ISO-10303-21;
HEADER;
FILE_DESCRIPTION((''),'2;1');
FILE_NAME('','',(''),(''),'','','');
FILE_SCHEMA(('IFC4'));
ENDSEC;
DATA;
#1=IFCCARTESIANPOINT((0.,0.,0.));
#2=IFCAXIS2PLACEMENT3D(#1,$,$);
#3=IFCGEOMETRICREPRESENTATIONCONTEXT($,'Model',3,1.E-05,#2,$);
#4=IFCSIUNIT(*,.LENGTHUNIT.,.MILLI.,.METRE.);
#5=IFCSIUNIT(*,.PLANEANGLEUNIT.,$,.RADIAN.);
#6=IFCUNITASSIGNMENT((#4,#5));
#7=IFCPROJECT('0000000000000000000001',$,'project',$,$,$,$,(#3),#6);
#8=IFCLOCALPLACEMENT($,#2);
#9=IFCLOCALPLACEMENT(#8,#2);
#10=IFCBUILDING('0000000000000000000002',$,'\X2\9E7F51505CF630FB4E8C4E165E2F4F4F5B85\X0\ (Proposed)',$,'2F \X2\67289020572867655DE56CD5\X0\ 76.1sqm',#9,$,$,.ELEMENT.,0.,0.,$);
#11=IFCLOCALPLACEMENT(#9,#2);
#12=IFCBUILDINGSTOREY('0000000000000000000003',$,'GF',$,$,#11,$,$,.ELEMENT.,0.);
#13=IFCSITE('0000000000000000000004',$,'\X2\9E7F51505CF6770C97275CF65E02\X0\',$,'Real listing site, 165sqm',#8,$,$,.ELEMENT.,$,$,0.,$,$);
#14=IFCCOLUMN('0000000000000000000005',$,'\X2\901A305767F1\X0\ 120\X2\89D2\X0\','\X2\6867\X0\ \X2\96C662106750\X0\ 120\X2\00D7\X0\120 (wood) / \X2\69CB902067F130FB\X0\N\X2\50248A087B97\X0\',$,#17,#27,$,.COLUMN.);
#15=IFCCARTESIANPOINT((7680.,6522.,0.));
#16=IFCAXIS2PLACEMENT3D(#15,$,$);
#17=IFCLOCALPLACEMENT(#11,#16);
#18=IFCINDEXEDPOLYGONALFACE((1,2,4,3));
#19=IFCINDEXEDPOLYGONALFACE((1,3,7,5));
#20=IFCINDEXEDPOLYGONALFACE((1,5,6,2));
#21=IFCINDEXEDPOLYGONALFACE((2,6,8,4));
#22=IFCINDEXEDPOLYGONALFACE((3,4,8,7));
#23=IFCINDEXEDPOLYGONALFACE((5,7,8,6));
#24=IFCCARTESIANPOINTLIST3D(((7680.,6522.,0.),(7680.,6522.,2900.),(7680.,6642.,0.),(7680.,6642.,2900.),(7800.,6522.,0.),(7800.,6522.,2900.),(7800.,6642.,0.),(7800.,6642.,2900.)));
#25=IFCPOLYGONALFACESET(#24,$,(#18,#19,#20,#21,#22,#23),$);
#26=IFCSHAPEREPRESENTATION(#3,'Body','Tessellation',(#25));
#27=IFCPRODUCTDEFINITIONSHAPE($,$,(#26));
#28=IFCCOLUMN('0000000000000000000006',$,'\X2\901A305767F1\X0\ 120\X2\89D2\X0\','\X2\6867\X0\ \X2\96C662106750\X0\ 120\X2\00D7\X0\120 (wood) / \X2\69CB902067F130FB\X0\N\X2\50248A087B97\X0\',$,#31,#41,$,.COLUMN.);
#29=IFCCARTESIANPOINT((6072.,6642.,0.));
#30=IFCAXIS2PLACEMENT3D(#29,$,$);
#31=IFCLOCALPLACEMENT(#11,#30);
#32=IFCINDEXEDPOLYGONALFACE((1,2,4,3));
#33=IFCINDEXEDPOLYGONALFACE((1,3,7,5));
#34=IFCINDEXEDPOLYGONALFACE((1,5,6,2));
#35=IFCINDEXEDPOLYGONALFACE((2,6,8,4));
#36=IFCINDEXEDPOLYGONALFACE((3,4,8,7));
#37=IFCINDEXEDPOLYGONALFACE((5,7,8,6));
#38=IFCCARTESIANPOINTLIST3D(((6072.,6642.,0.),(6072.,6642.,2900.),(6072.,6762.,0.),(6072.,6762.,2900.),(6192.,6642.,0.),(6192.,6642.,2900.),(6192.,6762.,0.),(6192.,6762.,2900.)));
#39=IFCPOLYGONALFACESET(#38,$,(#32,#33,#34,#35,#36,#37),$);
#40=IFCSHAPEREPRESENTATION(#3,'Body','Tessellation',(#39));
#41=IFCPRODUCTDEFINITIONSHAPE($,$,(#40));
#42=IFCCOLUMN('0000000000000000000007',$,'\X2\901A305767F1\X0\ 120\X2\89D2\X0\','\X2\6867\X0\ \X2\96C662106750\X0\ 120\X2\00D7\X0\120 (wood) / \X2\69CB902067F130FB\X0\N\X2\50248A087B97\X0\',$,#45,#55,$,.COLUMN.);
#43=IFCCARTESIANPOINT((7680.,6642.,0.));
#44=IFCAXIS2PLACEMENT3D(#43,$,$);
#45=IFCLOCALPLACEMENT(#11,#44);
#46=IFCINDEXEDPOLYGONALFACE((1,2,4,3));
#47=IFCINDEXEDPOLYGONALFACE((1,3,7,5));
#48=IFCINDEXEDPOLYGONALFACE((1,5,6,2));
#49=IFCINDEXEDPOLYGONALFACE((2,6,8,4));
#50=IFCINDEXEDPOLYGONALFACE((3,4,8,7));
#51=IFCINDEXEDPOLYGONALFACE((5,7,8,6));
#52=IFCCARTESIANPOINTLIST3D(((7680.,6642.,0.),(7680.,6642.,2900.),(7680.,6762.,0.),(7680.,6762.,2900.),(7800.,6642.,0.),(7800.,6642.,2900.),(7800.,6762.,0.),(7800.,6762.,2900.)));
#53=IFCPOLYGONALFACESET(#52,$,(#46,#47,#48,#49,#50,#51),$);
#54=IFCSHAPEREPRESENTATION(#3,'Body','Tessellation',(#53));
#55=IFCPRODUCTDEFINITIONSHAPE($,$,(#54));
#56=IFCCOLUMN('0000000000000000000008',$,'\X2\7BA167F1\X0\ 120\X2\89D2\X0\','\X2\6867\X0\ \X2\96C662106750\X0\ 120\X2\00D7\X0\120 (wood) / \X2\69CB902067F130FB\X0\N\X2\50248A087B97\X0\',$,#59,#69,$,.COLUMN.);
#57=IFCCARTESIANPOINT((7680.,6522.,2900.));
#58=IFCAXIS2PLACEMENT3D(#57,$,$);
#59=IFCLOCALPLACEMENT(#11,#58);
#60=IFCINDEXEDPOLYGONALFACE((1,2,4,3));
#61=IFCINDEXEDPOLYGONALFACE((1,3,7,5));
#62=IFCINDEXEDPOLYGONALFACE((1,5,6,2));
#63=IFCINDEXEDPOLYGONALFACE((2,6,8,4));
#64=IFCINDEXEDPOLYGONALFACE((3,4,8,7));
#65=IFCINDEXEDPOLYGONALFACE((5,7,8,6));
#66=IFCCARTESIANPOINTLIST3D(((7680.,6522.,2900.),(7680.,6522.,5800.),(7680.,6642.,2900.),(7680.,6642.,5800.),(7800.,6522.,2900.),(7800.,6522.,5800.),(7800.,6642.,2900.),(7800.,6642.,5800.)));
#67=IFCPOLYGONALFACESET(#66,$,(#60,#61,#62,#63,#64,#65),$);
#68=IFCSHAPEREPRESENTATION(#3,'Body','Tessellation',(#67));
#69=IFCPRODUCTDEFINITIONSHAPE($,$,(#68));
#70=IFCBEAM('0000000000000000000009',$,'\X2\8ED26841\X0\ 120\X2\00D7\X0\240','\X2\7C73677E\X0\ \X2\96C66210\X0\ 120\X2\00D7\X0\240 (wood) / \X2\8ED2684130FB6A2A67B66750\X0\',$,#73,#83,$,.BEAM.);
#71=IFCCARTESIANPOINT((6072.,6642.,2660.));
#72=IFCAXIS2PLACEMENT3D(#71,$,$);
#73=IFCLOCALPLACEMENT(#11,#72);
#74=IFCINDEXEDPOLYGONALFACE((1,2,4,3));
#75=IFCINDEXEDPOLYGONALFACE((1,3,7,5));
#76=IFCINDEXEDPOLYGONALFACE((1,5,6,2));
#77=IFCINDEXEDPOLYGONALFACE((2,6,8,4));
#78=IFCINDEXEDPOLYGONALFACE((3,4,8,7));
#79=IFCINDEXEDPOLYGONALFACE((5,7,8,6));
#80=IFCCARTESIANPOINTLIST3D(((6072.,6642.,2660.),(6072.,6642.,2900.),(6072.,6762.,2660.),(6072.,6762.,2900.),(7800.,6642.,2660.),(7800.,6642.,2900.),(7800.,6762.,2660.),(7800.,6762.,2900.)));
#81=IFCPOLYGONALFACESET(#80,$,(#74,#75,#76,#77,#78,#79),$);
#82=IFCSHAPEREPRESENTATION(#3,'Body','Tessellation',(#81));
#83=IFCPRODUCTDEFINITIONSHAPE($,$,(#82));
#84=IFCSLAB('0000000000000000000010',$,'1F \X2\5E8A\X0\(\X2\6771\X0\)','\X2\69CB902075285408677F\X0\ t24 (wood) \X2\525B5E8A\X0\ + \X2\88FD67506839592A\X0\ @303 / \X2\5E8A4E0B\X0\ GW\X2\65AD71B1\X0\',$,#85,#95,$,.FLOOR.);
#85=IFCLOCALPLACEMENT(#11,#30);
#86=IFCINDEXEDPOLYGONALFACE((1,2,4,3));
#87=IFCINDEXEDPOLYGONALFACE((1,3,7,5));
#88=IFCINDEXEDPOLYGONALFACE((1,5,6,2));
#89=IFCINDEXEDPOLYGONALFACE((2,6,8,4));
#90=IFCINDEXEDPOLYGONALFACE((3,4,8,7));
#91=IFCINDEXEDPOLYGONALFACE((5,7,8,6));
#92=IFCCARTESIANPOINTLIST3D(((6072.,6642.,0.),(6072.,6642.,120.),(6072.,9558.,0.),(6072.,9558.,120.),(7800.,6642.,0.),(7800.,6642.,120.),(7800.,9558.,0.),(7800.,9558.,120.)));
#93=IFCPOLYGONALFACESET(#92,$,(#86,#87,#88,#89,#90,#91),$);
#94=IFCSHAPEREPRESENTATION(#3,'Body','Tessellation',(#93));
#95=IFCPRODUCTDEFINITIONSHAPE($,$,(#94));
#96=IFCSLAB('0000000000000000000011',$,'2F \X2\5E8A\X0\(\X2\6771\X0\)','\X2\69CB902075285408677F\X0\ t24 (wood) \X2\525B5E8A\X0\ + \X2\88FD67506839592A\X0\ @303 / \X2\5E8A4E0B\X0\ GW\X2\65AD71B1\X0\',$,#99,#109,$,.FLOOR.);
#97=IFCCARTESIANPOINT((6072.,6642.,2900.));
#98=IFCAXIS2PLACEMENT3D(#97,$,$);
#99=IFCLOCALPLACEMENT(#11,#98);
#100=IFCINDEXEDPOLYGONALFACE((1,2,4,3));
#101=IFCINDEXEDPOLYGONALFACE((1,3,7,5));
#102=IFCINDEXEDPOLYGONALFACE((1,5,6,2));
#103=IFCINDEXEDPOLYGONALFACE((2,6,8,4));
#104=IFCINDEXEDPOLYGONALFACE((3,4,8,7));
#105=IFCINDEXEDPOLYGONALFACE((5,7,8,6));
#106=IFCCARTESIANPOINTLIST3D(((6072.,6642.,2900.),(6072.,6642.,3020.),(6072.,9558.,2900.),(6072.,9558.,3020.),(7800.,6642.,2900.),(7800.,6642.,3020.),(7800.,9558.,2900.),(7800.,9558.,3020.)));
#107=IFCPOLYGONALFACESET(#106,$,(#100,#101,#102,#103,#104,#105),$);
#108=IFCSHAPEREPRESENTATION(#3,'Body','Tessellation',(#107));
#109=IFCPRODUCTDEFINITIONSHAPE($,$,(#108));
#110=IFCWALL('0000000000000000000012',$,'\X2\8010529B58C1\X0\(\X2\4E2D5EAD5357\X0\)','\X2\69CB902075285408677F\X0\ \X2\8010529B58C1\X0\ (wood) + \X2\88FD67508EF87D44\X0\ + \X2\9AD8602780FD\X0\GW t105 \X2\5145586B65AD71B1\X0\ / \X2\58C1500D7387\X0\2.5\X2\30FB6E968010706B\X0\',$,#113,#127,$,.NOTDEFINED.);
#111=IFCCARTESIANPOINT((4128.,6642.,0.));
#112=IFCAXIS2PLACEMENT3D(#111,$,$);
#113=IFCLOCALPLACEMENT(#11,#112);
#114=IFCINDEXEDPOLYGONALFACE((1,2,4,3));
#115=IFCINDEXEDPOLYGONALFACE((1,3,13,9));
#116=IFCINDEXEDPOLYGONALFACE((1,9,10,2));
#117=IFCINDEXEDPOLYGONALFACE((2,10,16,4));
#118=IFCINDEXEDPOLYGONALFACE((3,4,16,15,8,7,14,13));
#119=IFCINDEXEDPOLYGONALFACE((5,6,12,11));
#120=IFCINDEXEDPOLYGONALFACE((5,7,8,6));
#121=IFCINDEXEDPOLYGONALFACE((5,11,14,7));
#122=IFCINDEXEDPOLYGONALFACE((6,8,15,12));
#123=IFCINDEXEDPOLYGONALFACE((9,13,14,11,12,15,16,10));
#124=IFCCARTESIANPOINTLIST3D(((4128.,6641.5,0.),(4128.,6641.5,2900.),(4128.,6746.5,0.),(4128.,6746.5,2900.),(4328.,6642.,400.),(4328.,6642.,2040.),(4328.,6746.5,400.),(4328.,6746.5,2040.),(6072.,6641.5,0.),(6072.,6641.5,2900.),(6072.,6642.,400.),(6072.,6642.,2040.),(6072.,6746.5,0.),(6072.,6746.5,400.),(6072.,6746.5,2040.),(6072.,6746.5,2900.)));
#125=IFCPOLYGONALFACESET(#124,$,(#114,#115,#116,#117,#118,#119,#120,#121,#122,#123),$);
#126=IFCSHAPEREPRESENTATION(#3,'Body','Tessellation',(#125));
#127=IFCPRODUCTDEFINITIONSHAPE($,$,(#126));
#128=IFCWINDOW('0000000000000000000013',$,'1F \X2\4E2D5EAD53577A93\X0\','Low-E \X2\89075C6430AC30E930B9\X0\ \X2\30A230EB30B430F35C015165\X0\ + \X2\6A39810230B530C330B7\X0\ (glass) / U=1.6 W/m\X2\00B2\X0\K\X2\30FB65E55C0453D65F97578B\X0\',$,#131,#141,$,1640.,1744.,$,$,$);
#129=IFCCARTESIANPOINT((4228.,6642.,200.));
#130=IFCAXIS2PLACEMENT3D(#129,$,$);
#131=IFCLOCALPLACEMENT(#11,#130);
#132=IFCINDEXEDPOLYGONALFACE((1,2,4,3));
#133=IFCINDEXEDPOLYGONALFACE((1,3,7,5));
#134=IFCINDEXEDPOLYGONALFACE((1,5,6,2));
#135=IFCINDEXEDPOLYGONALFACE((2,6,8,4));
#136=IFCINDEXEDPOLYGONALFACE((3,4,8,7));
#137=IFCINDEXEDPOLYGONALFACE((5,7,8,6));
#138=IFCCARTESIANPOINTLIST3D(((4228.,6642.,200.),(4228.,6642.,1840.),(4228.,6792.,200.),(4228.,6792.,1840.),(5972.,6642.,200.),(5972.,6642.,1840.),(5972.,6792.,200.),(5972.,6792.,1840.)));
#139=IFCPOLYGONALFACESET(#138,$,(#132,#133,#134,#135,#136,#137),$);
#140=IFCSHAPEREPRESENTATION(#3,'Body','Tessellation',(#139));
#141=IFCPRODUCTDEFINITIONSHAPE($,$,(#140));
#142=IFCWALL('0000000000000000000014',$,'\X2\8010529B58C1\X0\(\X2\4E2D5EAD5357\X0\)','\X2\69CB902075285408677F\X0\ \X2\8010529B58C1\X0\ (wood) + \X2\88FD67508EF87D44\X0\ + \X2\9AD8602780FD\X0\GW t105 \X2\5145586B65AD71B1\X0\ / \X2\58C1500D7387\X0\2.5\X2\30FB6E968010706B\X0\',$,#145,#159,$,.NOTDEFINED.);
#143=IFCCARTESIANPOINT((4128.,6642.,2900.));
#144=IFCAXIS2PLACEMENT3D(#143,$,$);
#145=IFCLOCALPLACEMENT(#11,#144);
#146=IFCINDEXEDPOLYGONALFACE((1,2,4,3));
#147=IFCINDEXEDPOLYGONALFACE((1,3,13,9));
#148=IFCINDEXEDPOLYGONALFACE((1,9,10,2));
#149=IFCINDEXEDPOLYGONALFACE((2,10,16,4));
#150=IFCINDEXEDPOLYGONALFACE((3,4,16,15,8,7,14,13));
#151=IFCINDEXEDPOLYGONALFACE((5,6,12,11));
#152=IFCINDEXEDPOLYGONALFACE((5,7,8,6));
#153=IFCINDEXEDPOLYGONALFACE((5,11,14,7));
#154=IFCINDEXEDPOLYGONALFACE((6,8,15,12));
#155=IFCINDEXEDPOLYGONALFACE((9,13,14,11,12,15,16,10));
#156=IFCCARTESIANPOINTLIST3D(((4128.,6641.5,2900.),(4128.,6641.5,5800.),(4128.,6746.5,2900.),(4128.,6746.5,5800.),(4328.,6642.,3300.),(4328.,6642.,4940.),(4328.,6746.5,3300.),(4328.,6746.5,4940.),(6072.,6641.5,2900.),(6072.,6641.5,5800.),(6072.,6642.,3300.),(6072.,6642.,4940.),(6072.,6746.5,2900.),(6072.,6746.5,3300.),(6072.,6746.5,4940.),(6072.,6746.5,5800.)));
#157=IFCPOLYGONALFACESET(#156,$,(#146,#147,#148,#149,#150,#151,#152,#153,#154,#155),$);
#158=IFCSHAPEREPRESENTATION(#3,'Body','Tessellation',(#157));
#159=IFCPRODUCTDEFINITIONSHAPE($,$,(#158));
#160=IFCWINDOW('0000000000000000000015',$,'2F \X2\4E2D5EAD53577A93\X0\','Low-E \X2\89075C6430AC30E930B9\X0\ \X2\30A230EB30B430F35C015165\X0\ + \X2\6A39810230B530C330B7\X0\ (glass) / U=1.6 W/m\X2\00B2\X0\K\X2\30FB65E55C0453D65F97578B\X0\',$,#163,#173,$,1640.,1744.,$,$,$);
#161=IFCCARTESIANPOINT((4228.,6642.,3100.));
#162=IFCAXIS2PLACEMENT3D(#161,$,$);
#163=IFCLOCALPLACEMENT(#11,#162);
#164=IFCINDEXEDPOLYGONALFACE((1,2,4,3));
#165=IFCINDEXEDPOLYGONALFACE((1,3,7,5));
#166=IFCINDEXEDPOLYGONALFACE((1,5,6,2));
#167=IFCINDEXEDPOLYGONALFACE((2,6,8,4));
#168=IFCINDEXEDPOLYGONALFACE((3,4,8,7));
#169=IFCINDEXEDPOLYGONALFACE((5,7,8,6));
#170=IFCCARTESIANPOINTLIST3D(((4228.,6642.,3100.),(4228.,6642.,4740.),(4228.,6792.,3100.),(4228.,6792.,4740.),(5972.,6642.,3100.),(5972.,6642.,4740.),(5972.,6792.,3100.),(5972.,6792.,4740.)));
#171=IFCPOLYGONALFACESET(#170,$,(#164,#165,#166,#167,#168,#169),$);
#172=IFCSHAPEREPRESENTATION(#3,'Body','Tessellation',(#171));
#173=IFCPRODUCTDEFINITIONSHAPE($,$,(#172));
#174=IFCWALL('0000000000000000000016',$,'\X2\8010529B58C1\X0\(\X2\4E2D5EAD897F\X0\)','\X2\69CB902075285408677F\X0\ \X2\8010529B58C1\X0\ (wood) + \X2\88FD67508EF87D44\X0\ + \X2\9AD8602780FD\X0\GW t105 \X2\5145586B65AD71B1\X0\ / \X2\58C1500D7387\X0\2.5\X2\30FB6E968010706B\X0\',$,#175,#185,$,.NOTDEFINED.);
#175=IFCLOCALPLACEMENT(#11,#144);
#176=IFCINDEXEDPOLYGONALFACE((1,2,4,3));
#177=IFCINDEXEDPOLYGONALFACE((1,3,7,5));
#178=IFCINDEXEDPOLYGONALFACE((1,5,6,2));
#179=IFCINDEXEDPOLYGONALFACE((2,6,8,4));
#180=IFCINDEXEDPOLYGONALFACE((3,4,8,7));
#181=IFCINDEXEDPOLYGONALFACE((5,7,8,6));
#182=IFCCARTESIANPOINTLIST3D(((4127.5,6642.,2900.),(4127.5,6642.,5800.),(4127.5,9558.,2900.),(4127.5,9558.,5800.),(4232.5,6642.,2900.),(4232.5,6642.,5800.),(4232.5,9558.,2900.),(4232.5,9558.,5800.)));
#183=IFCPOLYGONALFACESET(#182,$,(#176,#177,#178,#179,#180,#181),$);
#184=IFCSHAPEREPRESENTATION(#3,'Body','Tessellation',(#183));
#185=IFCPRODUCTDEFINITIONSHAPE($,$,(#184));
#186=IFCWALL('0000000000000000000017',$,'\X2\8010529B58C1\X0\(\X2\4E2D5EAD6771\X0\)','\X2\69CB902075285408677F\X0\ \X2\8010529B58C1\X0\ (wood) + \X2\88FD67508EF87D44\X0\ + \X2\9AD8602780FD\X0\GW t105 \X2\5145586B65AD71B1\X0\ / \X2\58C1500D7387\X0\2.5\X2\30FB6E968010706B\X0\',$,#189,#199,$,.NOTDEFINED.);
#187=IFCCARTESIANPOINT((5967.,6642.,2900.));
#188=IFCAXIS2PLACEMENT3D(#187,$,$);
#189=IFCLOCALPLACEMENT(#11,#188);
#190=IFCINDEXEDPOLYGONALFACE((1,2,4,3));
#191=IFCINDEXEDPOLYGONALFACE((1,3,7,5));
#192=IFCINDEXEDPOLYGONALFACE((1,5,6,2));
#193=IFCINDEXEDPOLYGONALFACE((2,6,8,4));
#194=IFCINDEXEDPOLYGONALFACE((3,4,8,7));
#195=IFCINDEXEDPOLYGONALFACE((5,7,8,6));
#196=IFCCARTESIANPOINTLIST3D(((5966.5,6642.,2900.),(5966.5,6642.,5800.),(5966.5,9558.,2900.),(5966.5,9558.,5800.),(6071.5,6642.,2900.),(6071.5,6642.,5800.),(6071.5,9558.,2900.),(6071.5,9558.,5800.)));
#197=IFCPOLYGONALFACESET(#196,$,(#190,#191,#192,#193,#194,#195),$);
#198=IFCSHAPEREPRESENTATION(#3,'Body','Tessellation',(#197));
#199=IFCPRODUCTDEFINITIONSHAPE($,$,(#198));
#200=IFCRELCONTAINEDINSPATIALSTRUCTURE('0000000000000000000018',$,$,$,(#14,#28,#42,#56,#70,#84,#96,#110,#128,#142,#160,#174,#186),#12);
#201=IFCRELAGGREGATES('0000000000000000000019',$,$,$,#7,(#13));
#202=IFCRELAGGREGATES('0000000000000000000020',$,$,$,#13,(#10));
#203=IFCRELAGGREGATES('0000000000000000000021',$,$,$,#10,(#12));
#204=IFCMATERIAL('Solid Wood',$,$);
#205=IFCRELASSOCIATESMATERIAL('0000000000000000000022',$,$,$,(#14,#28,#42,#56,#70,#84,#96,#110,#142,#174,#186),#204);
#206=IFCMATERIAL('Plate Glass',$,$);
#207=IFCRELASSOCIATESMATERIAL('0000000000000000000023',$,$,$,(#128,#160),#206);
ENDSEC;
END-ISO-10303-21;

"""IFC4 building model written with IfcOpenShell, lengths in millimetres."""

from ifc_helpers import new_model, si_unit, frame, frame_2d, origin, place, context, project, spatial, rectangle, extrude, material, element, fill, save


model = new_model("IFC4")

# Units and contexts
model_context = context("Model", 3, precision=1e-05, world=origin())
ifc_project = project(units=[si_unit("LENGTHUNIT", "METRE", prefix="MILLI"), si_unit("PLANEANGLEUNIT", "RADIAN")], contexts=[model_context])

# Site, building, storey
site_placement = place(None, origin())
site = spatial("IfcSite", under=ifc_project, at=site_placement, Name="鹿児島県霧島市", ObjectType="Real listing site, 165sqm", CompositionType="ELEMENT", RefElevation=0.0)
building_placement = place(site_placement, origin())
building = spatial("IfcBuilding", under=site, at=building_placement, Name="鹿児島・二世帯住宅 (Proposed)", ObjectType="2F 木造在来工法 76.1sqm", CompositionType="ELEMENT", ElevationOfRefHeight=0.0, ElevationOfTerrain=0.0)
storey_placement = place(building_placement, origin())
storey = spatial("IfcBuildingStorey", under=building, at=storey_placement, Name="GF", CompositionType="ELEMENT", Elevation=0.0)

# Columns
ifc_material_1 = material(Name="Solid Wood")
column_1_placement = place(storey_placement, frame((7680.0, 6522.0, 0.0)))
element("IfcColumn", 1, at=column_1_placement, inside=storey, material=ifc_material_1, Name="通し柱 120角", Description="桧 集成材 120×120 (wood) / 構造柱・N値計算", PredefinedType="COLUMN", context=model_context, shape_type="SweptSolid", body=[
    extrude(rectangle(XDim=120.0, YDim=120.0, at=frame_2d((60.0, 60.0))), frame((7680.0, 6522.0, 0.0)), (0.0, 0.0, 1.0), 2900.0),
])
column_2_placement = place(storey_placement, frame((6072.0, 6642.0, 0.0)))
element("IfcColumn", 2, at=column_2_placement, inside=storey, material=ifc_material_1, Name="通し柱 120角", Description="桧 集成材 120×120 (wood) / 構造柱・N値計算", PredefinedType="COLUMN", context=model_context, shape_type="SweptSolid", body=[
    extrude(rectangle(XDim=120.0, YDim=120.0, at=frame_2d((60.0, 60.0))), frame((6072.0, 6642.0, 0.0)), (0.0, 0.0, 1.0), 2900.0),
])
column_3_placement = place(storey_placement, frame((7680.0, 6642.0, 0.0)))
element("IfcColumn", 3, at=column_3_placement, inside=storey, material=ifc_material_1, Name="通し柱 120角", Description="桧 集成材 120×120 (wood) / 構造柱・N値計算", PredefinedType="COLUMN", context=model_context, shape_type="SweptSolid", body=[
    extrude(rectangle(XDim=120.0, YDim=120.0, at=frame_2d((60.0, 60.0))), frame((7680.0, 6642.0, 0.0)), (0.0, 0.0, 1.0), 2900.0),
])
column_4_placement = place(storey_placement, frame((7680.0, 6522.0, 2900.0)))
element("IfcColumn", 4, at=column_4_placement, inside=storey, material=ifc_material_1, Name="管柱 120角", Description="桧 集成材 120×120 (wood) / 構造柱・N値計算", PredefinedType="COLUMN", context=model_context, shape_type="SweptSolid", body=[
    extrude(rectangle(XDim=120.0, YDim=120.0, at=frame_2d((60.0, 60.0))), frame((7680.0, 6522.0, 2900.0)), (0.0, 0.0, 1.0), 2900.0),
])

# Beam
beam_1_placement = place(storey_placement, frame((6072.0, 6642.0, 2660.0)))
element("IfcBeam", 5, at=beam_1_placement, inside=storey, material=ifc_material_1, Name="軒桁 120×240", Description="米松 集成 120×240 (wood) / 軒桁・横架材", PredefinedType="BEAM", context=model_context, shape_type="SweptSolid", body=[
    extrude(rectangle(XDim=1728.0, YDim=120.0, at=frame_2d((864.0, 60.0))), frame((6072.0, 6642.0, 2660.0)), (0.0, 0.0, 1.0), 240.0),
])

# Slabs
slab_1_placement = place(storey_placement, frame((6072.0, 6642.0, 0.0)))
element("IfcSlab", 6, at=slab_1_placement, inside=storey, material=ifc_material_1, Name="1F 床(東)", Description="構造用合板 t24 (wood) 剛床 + 製材根太 @303 / 床下 GW断熱", PredefinedType="FLOOR", context=model_context, shape_type="SweptSolid", body=[
    extrude(rectangle(XDim=1728.0, YDim=2916.0, at=frame_2d((864.0, 1458.0))), frame((6072.0, 6642.0, 0.0)), (0.0, 0.0, 1.0), 120.0),
])
slab_2_placement = place(storey_placement, frame((6072.0, 6642.0, 2900.0)))
element("IfcSlab", 7, at=slab_2_placement, inside=storey, material=ifc_material_1, Name="2F 床(東)", Description="構造用合板 t24 (wood) 剛床 + 製材根太 @303 / 床下 GW断熱", PredefinedType="FLOOR", context=model_context, shape_type="SweptSolid", body=[
    extrude(rectangle(XDim=1728.0, YDim=2916.0, at=frame_2d((864.0, 1458.0))), frame((6072.0, 6642.0, 2900.0)), (0.0, 0.0, 1.0), 120.0),
])

# Wall, opening, window
wall_1_placement = place(storey_placement, frame((4128.0, 6642.0, 0.0)))
wall_1 = element("IfcWall", 8, at=wall_1_placement, inside=storey, material=ifc_material_1, Name="耐力壁(中庭南)", Description="構造用合板 耐力壁 (wood) + 製材軸組 + 高性能GW t105 充填断熱 / 壁倍率2.5・準耐火", PredefinedType="NOTDEFINED", context=model_context, shape_type="SweptSolid", body=[
    extrude(rectangle(XDim=1944.0, YDim=105.0, at=frame_2d((972.0, 52.0))), frame((4128.0, 6642.0, 0.0)), (0.0, 0.0, 1.0), 2900.0),
])
opening_1_placement = place(storey_placement, frame((4228.0, 6642.0, 200.0)))
opening_1 = element("IfcOpeningElement", 9, at=opening_1_placement, cuts=wall_1, PredefinedType="NOTDEFINED", context=model_context, shape_type="SweptSolid", body=[
    extrude(rectangle(XDim=1744.0, YDim=150.0, at=frame_2d((872.0, 75.0))), frame((4228.0, 6642.0, 200.0)), (0.0, 0.0, 1.0), 1640.0),
])
ifc_material_2 = material(Name="Plate Glass")
window_1_placement = place(storey_placement, frame((4228.0, 6642.0, 200.0)))
window_1 = element("IfcWindow", 10, at=window_1_placement, inside=storey, material=ifc_material_2, Name="1F 中庭南窓", Description="Low-E 複層ガラス アルゴン封入 + 樹脂サッシ (glass) / U=1.6 W/m²K・日射取得型", OverallHeight=1640.0, OverallWidth=1744.0, context=model_context, shape_type="SweptSolid", body=[
    extrude(rectangle(XDim=1744.0, YDim=150.0, at=frame_2d((872.0, 75.0))), frame((4228.0, 6642.0, 200.0)), (0.0, 0.0, 1.0), 1640.0),
])
fill(opening_1, window_1)

# Wall, opening, window
wall_2_placement = place(storey_placement, frame((4128.0, 6642.0, 2900.0)))
wall_2 = element("IfcWall", 11, at=wall_2_placement, inside=storey, material=ifc_material_1, Name="耐力壁(中庭南)", Description="構造用合板 耐力壁 (wood) + 製材軸組 + 高性能GW t105 充填断熱 / 壁倍率2.5・準耐火", PredefinedType="NOTDEFINED", context=model_context, shape_type="SweptSolid", body=[
    extrude(rectangle(XDim=1944.0, YDim=105.0, at=frame_2d((972.0, 52.0))), frame((4128.0, 6642.0, 2900.0)), (0.0, 0.0, 1.0), 2900.0),
])
opening_2_placement = place(storey_placement, frame((4228.0, 6642.0, 3100.0)))
opening_2 = element("IfcOpeningElement", 12, at=opening_2_placement, cuts=wall_2, PredefinedType="NOTDEFINED", context=model_context, shape_type="SweptSolid", body=[
    extrude(rectangle(XDim=1744.0, YDim=150.0, at=frame_2d((872.0, 75.0))), frame((4228.0, 6642.0, 3100.0)), (0.0, 0.0, 1.0), 1640.0),
])
window_2_placement = place(storey_placement, frame((4228.0, 6642.0, 3100.0)))
window_2 = element("IfcWindow", 13, at=window_2_placement, inside=storey, material=ifc_material_2, Name="2F 中庭南窓", Description="Low-E 複層ガラス アルゴン封入 + 樹脂サッシ (glass) / U=1.6 W/m²K・日射取得型", OverallHeight=1640.0, OverallWidth=1744.0, context=model_context, shape_type="SweptSolid", body=[
    extrude(rectangle(XDim=1744.0, YDim=150.0, at=frame_2d((872.0, 75.0))), frame((4228.0, 6642.0, 3100.0)), (0.0, 0.0, 1.0), 1640.0),
])
fill(opening_2, window_2)

# Walls
wall_3_placement = place(storey_placement, frame((4128.0, 6642.0, 2900.0)))
element("IfcWall", 14, at=wall_3_placement, inside=storey, material=ifc_material_1, Name="耐力壁(中庭西)", Description="構造用合板 耐力壁 (wood) + 製材軸組 + 高性能GW t105 充填断熱 / 壁倍率2.5・準耐火", PredefinedType="NOTDEFINED", context=model_context, shape_type="SweptSolid", body=[
    extrude(rectangle(XDim=105.0, YDim=2916.0, at=frame_2d((52.0, 1458.0))), frame((4128.0, 6642.0, 2900.0)), (0.0, 0.0, 1.0), 2900.0),
])
wall_4_placement = place(storey_placement, frame((5967.0, 6642.0, 2900.0)))
element("IfcWall", 15, at=wall_4_placement, inside=storey, material=ifc_material_1, Name="耐力壁(中庭東)", Description="構造用合板 耐力壁 (wood) + 製材軸組 + 高性能GW t105 充填断熱 / 壁倍率2.5・準耐火", PredefinedType="NOTDEFINED", context=model_context, shape_type="SweptSolid", body=[
    extrude(rectangle(XDim=105.0, YDim=2916.0, at=frame_2d((52.0, 1458.0))), frame((5967.0, 6642.0, 2900.0)), (0.0, 0.0, 1.0), 2900.0),
])

save(model, "model.ifc")
